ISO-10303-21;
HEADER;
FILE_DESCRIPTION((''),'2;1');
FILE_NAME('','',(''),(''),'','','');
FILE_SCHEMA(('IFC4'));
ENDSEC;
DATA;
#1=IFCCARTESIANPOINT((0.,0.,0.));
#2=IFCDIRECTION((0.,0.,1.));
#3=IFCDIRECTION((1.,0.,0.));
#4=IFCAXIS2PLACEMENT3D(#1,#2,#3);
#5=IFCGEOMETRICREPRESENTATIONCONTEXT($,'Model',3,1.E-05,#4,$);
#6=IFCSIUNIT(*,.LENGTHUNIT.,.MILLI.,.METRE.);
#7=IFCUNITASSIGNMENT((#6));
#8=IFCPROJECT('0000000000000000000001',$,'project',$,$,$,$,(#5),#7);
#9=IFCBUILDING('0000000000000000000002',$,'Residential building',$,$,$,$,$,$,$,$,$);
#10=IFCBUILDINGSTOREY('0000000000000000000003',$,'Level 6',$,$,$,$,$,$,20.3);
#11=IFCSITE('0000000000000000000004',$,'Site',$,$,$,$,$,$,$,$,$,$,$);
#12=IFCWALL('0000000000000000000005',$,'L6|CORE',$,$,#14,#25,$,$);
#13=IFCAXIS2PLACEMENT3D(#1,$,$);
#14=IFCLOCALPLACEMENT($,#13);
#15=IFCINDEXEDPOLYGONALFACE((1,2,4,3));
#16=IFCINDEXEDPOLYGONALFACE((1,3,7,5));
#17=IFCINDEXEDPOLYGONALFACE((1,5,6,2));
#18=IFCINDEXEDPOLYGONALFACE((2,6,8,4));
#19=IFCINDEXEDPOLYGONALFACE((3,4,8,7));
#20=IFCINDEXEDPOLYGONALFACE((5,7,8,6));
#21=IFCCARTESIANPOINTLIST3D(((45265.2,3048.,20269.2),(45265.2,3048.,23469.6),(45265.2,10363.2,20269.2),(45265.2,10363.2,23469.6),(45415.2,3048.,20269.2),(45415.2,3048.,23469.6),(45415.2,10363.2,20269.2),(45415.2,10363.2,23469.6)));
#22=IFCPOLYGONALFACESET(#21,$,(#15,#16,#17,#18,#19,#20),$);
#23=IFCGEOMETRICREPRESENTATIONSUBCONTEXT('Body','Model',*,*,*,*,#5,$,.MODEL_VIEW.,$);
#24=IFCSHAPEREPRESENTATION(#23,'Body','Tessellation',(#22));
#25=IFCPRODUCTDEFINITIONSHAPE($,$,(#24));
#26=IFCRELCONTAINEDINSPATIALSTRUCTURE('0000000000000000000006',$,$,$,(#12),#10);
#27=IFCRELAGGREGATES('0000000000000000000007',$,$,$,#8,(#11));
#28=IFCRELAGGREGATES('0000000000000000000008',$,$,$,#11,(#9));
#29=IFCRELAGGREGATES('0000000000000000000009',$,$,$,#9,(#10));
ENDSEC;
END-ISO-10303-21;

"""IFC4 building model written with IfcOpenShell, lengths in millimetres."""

from ifc_helpers import new_model, si_unit, frame, origin_with_axes, place, context, subcontext, project, spatial, indexed_curve, outline, extrude, element, save


model = new_model("IFC4")

# Units and contexts
model_context = context("Model", 3, precision=1e-05, world=origin_with_axes())
body_context = subcontext(model_context, "Body", "Model", "MODEL_VIEW")
ifc_project = project(units=[si_unit("LENGTHUNIT", "METRE", prefix="MILLI")], contexts=[model_context])

# Site, building, storey
site = spatial("IfcSite", under=ifc_project, Name="Site")
building = spatial("IfcBuilding", under=site, Name="Residential building")
storey = spatial("IfcBuildingStorey", under=building, Name="Level 6", Elevation=20.3)

# Wall
for number, where, z_axis, x_axis, name in (
    (1, (45415.2, 3048.0, 20269.2), (0.0, 0.0, 1.0), (0.0, 1.0, 0.0), "L6|CORE"),
):
    element("IfcWall", number, at=place(None, frame(where, z_axis=z_axis, x_axis=x_axis)), inside=storey, Name=name, context=body_context, shape_type="SweptSolid", body=[
        extrude(outline(indexed_curve([(0.0, 0.0), (0.0, 150.0), (7315.2, 150.0), (7315.2, 0.0), (0.0, 0.0)], self_intersect=False)), origin_with_axes(), (0.0, 0.0, 1.0), 3200.4),
    ])

save(model, "model.ifc")
